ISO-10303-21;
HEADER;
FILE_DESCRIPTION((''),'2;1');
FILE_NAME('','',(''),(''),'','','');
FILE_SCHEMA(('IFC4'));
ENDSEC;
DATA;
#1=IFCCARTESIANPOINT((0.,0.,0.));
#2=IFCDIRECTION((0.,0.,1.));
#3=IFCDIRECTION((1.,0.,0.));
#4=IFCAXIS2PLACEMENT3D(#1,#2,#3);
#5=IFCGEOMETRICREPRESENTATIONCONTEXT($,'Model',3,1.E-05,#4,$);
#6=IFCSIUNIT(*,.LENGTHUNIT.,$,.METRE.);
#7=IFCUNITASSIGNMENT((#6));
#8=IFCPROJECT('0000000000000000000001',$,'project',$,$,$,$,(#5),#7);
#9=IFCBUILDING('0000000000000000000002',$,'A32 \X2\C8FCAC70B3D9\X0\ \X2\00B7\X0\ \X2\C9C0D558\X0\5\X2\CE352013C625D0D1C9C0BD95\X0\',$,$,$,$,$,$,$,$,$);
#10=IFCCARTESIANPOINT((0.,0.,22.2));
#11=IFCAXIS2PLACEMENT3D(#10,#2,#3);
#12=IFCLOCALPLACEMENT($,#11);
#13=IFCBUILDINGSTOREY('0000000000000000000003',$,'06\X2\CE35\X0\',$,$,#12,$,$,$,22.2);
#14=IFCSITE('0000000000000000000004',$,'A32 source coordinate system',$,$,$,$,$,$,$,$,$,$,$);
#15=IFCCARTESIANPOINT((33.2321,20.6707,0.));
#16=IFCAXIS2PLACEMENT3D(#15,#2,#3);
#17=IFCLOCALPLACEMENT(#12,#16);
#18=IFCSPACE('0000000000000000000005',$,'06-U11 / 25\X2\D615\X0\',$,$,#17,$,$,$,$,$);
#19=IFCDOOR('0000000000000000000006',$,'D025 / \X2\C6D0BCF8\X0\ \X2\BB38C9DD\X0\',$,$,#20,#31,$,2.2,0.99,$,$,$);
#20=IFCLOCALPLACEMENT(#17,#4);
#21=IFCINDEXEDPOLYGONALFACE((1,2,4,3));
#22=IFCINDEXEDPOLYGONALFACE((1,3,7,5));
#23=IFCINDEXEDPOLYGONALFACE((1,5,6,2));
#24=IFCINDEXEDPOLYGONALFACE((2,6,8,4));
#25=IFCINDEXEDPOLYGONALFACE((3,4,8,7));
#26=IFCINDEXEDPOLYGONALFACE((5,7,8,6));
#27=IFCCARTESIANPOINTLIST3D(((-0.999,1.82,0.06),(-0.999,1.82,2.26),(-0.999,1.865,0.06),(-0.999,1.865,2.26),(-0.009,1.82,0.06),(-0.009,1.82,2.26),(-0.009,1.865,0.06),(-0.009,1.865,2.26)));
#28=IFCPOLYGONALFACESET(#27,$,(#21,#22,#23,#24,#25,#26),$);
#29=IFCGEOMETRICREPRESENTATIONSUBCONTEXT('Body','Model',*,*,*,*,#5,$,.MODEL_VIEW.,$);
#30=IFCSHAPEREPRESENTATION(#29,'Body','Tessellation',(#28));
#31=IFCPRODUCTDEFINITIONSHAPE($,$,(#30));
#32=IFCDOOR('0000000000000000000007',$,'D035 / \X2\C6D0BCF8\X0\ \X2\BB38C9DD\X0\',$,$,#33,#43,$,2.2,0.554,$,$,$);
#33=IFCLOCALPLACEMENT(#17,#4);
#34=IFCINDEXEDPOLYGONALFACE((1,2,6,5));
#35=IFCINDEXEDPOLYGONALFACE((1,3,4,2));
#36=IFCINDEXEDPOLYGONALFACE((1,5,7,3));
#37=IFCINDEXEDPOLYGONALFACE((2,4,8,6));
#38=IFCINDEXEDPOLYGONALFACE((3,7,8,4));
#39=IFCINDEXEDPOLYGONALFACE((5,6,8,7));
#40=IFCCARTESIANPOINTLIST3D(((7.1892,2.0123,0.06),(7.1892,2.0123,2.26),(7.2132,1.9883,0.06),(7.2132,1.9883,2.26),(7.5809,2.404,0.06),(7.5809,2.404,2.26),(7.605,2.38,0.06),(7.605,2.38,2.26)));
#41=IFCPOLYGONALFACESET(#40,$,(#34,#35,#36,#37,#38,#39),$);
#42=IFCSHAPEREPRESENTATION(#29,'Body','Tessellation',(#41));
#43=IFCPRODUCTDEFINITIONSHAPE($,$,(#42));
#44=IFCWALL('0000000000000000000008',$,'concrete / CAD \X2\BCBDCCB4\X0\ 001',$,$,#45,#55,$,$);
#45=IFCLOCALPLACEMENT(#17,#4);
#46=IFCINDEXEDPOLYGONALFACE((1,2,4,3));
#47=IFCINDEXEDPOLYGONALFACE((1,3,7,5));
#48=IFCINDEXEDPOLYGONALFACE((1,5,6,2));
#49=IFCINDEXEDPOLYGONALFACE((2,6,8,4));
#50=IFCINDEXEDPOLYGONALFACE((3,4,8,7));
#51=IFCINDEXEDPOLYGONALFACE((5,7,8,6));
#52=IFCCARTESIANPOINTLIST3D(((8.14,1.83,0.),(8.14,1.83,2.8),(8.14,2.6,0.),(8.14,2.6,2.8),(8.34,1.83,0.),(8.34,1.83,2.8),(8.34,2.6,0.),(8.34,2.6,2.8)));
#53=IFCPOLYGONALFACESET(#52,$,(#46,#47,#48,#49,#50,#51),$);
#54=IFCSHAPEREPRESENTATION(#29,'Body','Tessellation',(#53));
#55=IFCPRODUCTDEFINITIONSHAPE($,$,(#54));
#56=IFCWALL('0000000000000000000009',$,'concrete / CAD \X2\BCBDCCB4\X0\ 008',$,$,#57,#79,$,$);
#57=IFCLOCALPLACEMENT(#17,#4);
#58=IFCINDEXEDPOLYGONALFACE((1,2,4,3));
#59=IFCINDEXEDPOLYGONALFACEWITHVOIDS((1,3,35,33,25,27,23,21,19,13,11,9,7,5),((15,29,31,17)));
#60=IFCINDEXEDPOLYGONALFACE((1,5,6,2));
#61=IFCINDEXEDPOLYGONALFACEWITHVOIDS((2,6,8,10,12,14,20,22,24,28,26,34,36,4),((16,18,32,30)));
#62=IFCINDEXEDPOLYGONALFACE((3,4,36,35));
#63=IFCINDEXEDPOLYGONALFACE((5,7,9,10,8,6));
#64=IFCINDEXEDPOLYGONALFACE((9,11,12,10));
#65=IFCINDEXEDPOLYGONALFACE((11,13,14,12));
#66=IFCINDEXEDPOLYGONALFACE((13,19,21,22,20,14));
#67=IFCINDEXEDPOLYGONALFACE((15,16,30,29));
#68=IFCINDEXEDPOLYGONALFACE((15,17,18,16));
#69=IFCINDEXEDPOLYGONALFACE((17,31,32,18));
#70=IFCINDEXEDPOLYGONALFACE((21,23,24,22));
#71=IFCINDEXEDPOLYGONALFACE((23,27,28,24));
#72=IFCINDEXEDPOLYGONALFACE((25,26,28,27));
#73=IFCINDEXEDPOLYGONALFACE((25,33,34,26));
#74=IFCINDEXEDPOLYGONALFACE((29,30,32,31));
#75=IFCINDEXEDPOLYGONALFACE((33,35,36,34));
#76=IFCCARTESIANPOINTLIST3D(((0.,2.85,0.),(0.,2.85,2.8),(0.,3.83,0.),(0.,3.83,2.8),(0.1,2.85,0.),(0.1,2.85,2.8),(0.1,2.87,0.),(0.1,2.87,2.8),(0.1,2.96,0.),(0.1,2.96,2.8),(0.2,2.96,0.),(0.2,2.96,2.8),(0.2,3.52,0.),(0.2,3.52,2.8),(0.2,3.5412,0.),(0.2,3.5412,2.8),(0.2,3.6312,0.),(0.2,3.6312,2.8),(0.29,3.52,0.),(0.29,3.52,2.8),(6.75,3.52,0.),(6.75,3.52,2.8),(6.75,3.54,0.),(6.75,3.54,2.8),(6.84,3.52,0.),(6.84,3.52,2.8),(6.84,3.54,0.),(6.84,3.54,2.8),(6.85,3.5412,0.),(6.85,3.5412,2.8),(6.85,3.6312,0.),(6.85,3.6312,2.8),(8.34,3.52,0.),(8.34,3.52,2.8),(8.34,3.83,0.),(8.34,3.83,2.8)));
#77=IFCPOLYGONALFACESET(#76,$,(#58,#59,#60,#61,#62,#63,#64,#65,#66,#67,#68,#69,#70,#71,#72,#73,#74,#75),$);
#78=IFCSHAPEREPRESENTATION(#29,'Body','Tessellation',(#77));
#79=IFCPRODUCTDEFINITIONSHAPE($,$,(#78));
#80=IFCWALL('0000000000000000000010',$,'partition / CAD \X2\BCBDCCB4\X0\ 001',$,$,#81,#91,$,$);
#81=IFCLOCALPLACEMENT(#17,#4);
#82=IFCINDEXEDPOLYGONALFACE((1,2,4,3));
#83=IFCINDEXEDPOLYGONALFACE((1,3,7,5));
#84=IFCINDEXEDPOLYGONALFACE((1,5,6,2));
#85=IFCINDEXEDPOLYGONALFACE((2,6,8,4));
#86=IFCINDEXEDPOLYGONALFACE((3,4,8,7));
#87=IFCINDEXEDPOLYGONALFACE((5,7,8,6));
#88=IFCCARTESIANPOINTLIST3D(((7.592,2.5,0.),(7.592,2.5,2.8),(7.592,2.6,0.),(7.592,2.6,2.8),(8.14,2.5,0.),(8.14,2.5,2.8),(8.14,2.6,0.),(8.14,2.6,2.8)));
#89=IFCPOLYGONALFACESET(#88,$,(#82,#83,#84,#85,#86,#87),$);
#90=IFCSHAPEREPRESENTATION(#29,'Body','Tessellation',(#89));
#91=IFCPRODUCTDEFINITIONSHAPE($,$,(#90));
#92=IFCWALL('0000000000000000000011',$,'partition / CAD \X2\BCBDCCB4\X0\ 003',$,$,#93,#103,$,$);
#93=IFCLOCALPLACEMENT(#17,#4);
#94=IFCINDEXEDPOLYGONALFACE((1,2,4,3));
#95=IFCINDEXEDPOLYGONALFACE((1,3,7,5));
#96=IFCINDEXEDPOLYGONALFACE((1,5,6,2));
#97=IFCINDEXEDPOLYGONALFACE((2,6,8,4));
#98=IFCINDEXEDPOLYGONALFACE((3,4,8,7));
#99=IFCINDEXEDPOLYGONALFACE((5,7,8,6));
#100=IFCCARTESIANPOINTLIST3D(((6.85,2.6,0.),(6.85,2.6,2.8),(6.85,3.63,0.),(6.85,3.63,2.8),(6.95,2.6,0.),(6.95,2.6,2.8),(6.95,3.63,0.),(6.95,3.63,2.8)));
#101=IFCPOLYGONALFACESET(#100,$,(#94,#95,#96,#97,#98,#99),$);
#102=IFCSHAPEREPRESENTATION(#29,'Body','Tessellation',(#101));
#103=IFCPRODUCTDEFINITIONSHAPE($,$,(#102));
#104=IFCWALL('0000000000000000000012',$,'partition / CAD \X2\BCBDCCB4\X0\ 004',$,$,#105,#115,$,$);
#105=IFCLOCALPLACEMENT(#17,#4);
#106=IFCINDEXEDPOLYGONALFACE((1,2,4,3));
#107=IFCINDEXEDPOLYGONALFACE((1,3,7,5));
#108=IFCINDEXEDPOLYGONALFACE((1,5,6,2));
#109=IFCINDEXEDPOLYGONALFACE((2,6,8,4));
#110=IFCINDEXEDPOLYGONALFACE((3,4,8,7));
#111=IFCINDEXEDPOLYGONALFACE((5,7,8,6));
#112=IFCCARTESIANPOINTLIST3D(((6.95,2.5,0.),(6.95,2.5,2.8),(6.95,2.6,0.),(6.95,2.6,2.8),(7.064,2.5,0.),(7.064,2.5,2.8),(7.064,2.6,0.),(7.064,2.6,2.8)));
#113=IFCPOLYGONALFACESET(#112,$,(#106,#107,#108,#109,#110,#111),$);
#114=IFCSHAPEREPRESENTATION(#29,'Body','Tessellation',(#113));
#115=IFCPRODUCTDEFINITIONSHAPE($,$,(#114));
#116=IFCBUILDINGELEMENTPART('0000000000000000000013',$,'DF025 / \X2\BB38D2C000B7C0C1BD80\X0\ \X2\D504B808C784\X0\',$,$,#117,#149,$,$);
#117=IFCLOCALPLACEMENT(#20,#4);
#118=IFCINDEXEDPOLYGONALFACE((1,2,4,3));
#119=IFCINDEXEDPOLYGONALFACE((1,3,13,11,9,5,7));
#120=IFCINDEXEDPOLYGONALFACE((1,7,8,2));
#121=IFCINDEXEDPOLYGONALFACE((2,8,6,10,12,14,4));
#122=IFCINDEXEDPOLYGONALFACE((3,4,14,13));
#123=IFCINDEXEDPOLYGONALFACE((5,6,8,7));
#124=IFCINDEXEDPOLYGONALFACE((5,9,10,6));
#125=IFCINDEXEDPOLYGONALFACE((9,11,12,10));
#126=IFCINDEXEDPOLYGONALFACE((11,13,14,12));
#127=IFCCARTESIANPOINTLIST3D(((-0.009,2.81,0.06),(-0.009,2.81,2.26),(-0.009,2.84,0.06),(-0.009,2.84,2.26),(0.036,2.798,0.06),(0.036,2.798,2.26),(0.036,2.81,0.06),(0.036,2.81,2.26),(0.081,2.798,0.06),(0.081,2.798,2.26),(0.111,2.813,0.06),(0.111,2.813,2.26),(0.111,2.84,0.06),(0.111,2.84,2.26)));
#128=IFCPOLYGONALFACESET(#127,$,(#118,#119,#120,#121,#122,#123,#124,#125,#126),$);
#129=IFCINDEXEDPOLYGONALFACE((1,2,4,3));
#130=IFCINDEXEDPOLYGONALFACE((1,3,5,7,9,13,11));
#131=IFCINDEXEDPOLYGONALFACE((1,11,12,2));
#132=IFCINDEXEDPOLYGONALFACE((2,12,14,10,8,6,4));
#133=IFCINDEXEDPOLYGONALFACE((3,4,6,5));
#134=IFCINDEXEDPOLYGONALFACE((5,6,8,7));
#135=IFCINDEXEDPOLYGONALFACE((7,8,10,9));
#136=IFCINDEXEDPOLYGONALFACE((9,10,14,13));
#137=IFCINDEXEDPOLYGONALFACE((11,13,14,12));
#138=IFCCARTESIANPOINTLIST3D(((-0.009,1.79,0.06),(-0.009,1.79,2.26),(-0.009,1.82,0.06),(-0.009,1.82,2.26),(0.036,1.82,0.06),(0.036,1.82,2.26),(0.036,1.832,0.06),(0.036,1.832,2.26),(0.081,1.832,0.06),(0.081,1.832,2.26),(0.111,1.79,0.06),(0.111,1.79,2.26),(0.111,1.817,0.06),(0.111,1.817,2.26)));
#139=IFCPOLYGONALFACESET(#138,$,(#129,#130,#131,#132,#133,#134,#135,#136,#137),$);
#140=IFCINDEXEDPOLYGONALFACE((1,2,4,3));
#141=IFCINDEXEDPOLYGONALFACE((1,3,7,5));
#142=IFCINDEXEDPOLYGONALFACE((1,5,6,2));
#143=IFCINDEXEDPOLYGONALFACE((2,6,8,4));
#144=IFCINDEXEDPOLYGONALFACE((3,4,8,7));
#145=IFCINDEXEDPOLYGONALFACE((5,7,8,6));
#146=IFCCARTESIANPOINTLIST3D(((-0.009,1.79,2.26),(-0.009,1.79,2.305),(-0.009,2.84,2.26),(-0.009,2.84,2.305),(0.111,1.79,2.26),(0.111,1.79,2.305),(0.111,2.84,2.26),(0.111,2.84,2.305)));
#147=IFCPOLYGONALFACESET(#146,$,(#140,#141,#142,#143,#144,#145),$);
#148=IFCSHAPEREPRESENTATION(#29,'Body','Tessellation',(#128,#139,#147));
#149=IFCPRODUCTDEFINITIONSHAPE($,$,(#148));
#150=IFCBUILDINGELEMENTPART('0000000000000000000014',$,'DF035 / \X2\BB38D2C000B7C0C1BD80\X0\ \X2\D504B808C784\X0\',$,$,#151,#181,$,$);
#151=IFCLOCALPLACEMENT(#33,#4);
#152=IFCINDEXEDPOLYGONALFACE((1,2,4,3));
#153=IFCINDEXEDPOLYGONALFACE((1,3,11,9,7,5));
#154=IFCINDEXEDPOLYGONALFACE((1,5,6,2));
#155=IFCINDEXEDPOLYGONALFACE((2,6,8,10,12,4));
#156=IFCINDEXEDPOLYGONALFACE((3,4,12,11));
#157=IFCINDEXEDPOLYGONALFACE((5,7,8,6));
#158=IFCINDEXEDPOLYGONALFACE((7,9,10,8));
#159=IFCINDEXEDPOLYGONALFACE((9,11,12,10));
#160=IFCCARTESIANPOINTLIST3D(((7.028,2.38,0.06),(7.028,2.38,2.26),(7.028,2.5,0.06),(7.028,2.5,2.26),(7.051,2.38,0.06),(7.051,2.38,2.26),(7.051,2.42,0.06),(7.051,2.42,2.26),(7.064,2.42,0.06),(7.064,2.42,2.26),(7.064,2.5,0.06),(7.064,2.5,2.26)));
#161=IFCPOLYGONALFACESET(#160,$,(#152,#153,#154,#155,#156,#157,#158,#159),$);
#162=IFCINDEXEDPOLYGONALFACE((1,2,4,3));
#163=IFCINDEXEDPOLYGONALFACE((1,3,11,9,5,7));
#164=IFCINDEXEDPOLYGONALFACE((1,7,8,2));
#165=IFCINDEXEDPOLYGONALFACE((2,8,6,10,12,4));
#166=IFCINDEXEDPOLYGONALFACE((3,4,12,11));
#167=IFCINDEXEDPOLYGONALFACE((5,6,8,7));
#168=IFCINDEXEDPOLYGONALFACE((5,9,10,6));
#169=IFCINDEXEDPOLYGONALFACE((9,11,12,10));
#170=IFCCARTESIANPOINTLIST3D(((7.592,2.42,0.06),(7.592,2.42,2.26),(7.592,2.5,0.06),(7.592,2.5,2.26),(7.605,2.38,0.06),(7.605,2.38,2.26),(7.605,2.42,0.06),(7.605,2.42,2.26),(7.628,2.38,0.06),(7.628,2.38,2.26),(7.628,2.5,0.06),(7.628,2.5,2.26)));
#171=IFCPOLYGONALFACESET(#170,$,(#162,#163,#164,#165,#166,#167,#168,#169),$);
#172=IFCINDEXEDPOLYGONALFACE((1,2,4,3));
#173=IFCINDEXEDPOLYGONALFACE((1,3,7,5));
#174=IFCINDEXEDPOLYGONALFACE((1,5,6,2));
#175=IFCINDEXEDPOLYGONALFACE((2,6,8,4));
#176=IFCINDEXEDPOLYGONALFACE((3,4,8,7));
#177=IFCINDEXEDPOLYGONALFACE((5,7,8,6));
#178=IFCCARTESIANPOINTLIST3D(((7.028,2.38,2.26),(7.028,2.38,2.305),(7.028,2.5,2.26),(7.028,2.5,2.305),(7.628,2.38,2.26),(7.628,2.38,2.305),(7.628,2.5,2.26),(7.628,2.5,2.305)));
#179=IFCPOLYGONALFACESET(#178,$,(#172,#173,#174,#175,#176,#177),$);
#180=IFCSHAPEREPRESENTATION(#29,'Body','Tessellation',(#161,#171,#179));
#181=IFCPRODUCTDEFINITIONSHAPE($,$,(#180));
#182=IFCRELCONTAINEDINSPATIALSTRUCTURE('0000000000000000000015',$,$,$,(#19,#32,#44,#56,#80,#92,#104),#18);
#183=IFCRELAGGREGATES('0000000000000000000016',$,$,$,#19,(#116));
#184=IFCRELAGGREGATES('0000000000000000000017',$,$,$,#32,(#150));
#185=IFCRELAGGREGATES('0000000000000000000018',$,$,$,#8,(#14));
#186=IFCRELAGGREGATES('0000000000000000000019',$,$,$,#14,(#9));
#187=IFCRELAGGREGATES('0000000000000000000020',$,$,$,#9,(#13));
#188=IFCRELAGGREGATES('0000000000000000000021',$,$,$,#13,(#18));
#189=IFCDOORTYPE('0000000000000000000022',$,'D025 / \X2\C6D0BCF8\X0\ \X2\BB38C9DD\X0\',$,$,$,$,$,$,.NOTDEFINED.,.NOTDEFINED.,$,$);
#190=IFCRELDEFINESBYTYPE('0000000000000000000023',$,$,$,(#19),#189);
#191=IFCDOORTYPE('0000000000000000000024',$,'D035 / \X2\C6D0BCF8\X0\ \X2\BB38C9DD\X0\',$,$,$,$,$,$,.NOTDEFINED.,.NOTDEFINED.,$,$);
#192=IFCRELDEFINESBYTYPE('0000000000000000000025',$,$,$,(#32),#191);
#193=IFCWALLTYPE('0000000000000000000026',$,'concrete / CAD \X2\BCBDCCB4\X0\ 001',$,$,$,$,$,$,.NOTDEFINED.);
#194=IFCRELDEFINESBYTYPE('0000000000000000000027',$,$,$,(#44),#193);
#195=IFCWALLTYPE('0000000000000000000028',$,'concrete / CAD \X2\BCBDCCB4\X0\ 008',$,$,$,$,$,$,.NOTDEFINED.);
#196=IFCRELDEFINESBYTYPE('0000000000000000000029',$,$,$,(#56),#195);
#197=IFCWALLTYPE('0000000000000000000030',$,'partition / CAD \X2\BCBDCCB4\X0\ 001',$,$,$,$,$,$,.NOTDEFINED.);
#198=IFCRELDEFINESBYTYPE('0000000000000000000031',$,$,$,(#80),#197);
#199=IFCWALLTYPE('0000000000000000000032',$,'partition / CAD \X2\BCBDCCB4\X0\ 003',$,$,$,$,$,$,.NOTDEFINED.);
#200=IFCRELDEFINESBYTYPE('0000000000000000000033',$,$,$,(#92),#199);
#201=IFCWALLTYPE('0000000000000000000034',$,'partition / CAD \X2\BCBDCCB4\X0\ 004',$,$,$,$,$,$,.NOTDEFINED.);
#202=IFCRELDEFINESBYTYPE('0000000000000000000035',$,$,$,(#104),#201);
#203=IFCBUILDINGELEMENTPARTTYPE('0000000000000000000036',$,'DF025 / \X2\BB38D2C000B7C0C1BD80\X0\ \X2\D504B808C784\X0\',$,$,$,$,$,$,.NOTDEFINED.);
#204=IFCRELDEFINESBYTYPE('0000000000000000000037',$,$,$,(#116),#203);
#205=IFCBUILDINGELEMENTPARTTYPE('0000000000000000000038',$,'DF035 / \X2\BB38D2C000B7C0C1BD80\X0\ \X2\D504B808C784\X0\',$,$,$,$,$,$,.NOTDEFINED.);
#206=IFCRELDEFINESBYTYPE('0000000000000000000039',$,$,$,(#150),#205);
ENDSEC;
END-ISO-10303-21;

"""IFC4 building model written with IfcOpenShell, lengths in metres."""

from ifc_helpers import new_model, si_unit, frame, origin, origin_with_axes, place, context, subcontext, project, spatial, polyline, outline, extrude, source, transform, mapped, type_object, type_shapes, element, aggregate, save


model = new_model("IFC4")

# Units and contexts
model_context = context("Model", 3, precision=1e-05, world=origin_with_axes())
body_context = subcontext(model_context, "Body", "Model", "MODEL_VIEW")
ifc_project = project(units=[si_unit("LENGTHUNIT", "METRE")], contexts=[model_context])

# Site, building, storey, space
storey_placement = place(None, frame((0.0, 0.0, 22.2), z_axis=(0.0, 0.0, 1.0), x_axis=(1.0, 0.0, 0.0)))
space_placement = place(storey_placement, frame((33.2321, 20.6707, 0.0), z_axis=(0.0, 0.0, 1.0), x_axis=(1.0, 0.0, 0.0)))
site = spatial("IfcSite", under=ifc_project, Name="A32 source coordinate system")
building = spatial("IfcBuilding", under=site, Name="A32 주거동 · 지하5층–옥탑지붕")
storey = spatial("IfcBuildingStorey", under=building, at=storey_placement, Name="06층", Elevation=22.2)
space = spatial("IfcSpace", under=storey, at=space_placement, Name="06-U11 / 25형")

# Doors
door_type_1 = type_object("IfcDoorType", Name="D025 / 원본 문짝", OperationType="NOTDEFINED", PredefinedType="NOTDEFINED")
shared_shape_1 = source(origin(), body_context, "Body", "SweptSolid", [
    extrude(outline(polyline([(-0.009, 1.82), (-0.999, 1.82), (-0.999, 1.865), (-0.009, 1.865), (-0.009, 1.82)])), frame((0.0, 0.0, 0.06)), (0.0, 0.0, 1.0), 2.2),
])
type_shapes(door_type_1, [shared_shape_1])
door_1_placement = place(space_placement, origin_with_axes())
door_1 = element("IfcDoor", 1, at=door_1_placement, inside=space, type_object=door_type_1, Name="D025 / 원본 문짝", OverallHeight=2.2, OverallWidth=0.99, context=body_context, shape_type="MappedRepresentation", body=[
    mapped(shared_shape_1, transform((0.0, 0.0, 0.0), scale=1.0)),
])
door_type_2 = type_object("IfcDoorType", Name="D035 / 원본 문짝", OperationType="NOTDEFINED", PredefinedType="NOTDEFINED")
shared_shape_2 = source(origin(), body_context, "Body", "SweptSolid", [
    extrude(outline(polyline([(7.605, 2.38), (7.2132, 1.9883), (7.1892, 2.0123), (7.5809, 2.404), (7.605, 2.38)])), frame((0.0, 0.0, 0.06)), (0.0, 0.0, 1.0), 2.2),
])
type_shapes(door_type_2, [shared_shape_2])
door_2_placement = place(space_placement, origin_with_axes())
door_2 = element("IfcDoor", 2, at=door_2_placement, inside=space, type_object=door_type_2, Name="D035 / 원본 문짝", OverallHeight=2.2, OverallWidth=0.554, context=body_context, shape_type="MappedRepresentation", body=[
    mapped(shared_shape_2, transform((0.0, 0.0, 0.0), scale=1.0)),
])

# Walls
wall_type_1 = type_object("IfcWallType", Name="concrete / CAD 벽체 001", PredefinedType="NOTDEFINED")
shared_shape_3 = source(origin(), body_context, "Body", "SweptSolid", [
    extrude(outline(polyline([(8.34, 1.83), (8.14, 1.83), (8.14, 2.6), (8.34, 2.6), (8.34, 1.83)])), origin(), (0.0, 0.0, 1.0), 2.8),
])
type_shapes(wall_type_1, [shared_shape_3])
wall_1_placement = place(space_placement, origin_with_axes())
element("IfcWall", 3, at=wall_1_placement, inside=space, type_object=wall_type_1, Name="concrete / CAD 벽체 001", context=body_context, shape_type="MappedRepresentation", body=[
    mapped(shared_shape_3, transform((0.0, 0.0, 0.0), scale=1.0)),
])
wall_type_2 = type_object("IfcWallType", Name="concrete / CAD 벽체 008", PredefinedType="NOTDEFINED")
shared_shape_4 = source(origin(), body_context, "Body", "SweptSolid", [
    extrude(outline(polyline([(0.0, 3.83), (8.34, 3.83), (8.34, 3.52), (6.84, 3.52), (6.84, 3.54), (6.75, 3.54), (6.75, 3.52), (0.29, 3.52), (0.2, 3.52), (0.2, 2.96), (0.1, 2.96), (0.1, 2.87), (0.1, 2.85), (0.0, 2.85), (0.0, 3.83)]), holes=[polyline([(6.85, 3.5412), (6.85, 3.6312), (0.2, 3.6312), (0.2, 3.5412), (6.85, 3.5412)])]), origin(), (0.0, 0.0, 1.0), 2.8),
])
type_shapes(wall_type_2, [shared_shape_4])
wall_2_placement = place(space_placement, origin_with_axes())
element("IfcWall", 4, at=wall_2_placement, inside=space, type_object=wall_type_2, Name="concrete / CAD 벽체 008", context=body_context, shape_type="MappedRepresentation", body=[
    mapped(shared_shape_4, transform((0.0, 0.0, 0.0), scale=1.0)),
])
wall_type_3 = type_object("IfcWallType", Name="partition / CAD 벽체 001", PredefinedType="NOTDEFINED")
shared_shape_5 = source(origin(), body_context, "Body", "SweptSolid", [
    extrude(outline(polyline([(8.14, 2.6), (8.14, 2.5), (7.592, 2.5), (7.592, 2.6), (8.14, 2.6)])), origin(), (0.0, 0.0, 1.0), 2.8),
])
type_shapes(wall_type_3, [shared_shape_5])
wall_3_placement = place(space_placement, origin_with_axes())
element("IfcWall", 5, at=wall_3_placement, inside=space, type_object=wall_type_3, Name="partition / CAD 벽체 001", context=body_context, shape_type="MappedRepresentation", body=[
    mapped(shared_shape_5, transform((0.0, 0.0, 0.0), scale=1.0)),
])
wall_type_4 = type_object("IfcWallType", Name="partition / CAD 벽체 003", PredefinedType="NOTDEFINED")
shared_shape_6 = source(origin(), body_context, "Body", "SweptSolid", [
    extrude(outline(polyline([(6.85, 2.6), (6.85, 3.63), (6.95, 3.63), (6.95, 2.6), (6.85, 2.6)])), origin(), (0.0, 0.0, 1.0), 2.8),
])
type_shapes(wall_type_4, [shared_shape_6])
wall_4_placement = place(space_placement, origin_with_axes())
element("IfcWall", 6, at=wall_4_placement, inside=space, type_object=wall_type_4, Name="partition / CAD 벽체 003", context=body_context, shape_type="MappedRepresentation", body=[
    mapped(shared_shape_6, transform((0.0, 0.0, 0.0), scale=1.0)),
])
wall_type_5 = type_object("IfcWallType", Name="partition / CAD 벽체 004", PredefinedType="NOTDEFINED")
shared_shape_7 = source(origin(), body_context, "Body", "SweptSolid", [
    extrude(outline(polyline([(6.95, 2.5), (6.95, 2.6), (7.064, 2.6), (7.064, 2.5), (6.95, 2.5)])), origin(), (0.0, 0.0, 1.0), 2.8),
])
type_shapes(wall_type_5, [shared_shape_7])
wall_5_placement = place(space_placement, origin_with_axes())
element("IfcWall", 7, at=wall_5_placement, inside=space, type_object=wall_type_5, Name="partition / CAD 벽체 004", context=body_context, shape_type="MappedRepresentation", body=[
    mapped(shared_shape_7, transform((0.0, 0.0, 0.0), scale=1.0)),
])

# Building element parts
building_element_part_type_1 = type_object("IfcBuildingElementPartType", Name="DF025 / 문틀·상부 프레임", PredefinedType="NOTDEFINED")
shared_shape_8 = source(origin(), body_context, "Body", "SweptSolid", [
    extrude(outline(polyline([(0.111, 2.84), (0.111, 2.813), (0.081, 2.798), (0.036, 2.798), (0.036, 2.81), (-0.009, 2.81), (-0.009, 2.84), (0.111, 2.84)])), frame((0.0, 0.0, 0.06)), (0.0, 0.0, 1.0), 2.2),
    extrude(outline(polyline([(-0.009, 1.82), (0.036, 1.82), (0.036, 1.832), (0.081, 1.832), (0.111, 1.817), (0.111, 1.79), (-0.009, 1.79), (-0.009, 1.82)])), frame((0.0, 0.0, 0.06)), (0.0, 0.0, 1.0), 2.2),
    extrude(outline(polyline([(-0.009, 1.79), (-0.009, 2.84), (0.111, 2.84), (0.111, 1.79), (-0.009, 1.79)])), frame((0.0, 0.0, 2.26)), (0.0, 0.0, 1.0), 0.045),
])
type_shapes(building_element_part_type_1, [shared_shape_8])
building_element_part_1_placement = place(door_1_placement, origin_with_axes())
building_element_part_1 = element("IfcBuildingElementPart", 8, at=building_element_part_1_placement, type_object=building_element_part_type_1, Name="DF025 / 문틀·상부 프레임", context=body_context, shape_type="MappedRepresentation", body=[
    mapped(shared_shape_8, transform((0.0, 0.0, 0.0), scale=1.0)),
])
aggregate(door_1, [building_element_part_1])
building_element_part_type_2 = type_object("IfcBuildingElementPartType", Name="DF035 / 문틀·상부 프레임", PredefinedType="NOTDEFINED")
shared_shape_9 = source(origin(), body_context, "Body", "SweptSolid", [
    extrude(outline(polyline([(7.064, 2.5), (7.064, 2.42), (7.051, 2.42), (7.051, 2.38), (7.028, 2.38), (7.028, 2.5), (7.064, 2.5)])), frame((0.0, 0.0, 0.06)), (0.0, 0.0, 1.0), 2.2),
    extrude(outline(polyline([(7.628, 2.38), (7.605, 2.38), (7.605, 2.42), (7.592, 2.42), (7.592, 2.5), (7.628, 2.5), (7.628, 2.38)])), frame((0.0, 0.0, 0.06)), (0.0, 0.0, 1.0), 2.2),
    extrude(outline(polyline([(7.028, 2.38), (7.028, 2.5), (7.628, 2.5), (7.628, 2.38), (7.028, 2.38)])), frame((0.0, 0.0, 2.26)), (0.0, 0.0, 1.0), 0.045),
])
type_shapes(building_element_part_type_2, [shared_shape_9])
building_element_part_2_placement = place(door_2_placement, origin_with_axes())
building_element_part_2 = element("IfcBuildingElementPart", 9, at=building_element_part_2_placement, type_object=building_element_part_type_2, Name="DF035 / 문틀·상부 프레임", context=body_context, shape_type="MappedRepresentation", body=[
    mapped(shared_shape_9, transform((0.0, 0.0, 0.0), scale=1.0)),
])
aggregate(door_2, [building_element_part_2])

save(model, "model.ifc")
